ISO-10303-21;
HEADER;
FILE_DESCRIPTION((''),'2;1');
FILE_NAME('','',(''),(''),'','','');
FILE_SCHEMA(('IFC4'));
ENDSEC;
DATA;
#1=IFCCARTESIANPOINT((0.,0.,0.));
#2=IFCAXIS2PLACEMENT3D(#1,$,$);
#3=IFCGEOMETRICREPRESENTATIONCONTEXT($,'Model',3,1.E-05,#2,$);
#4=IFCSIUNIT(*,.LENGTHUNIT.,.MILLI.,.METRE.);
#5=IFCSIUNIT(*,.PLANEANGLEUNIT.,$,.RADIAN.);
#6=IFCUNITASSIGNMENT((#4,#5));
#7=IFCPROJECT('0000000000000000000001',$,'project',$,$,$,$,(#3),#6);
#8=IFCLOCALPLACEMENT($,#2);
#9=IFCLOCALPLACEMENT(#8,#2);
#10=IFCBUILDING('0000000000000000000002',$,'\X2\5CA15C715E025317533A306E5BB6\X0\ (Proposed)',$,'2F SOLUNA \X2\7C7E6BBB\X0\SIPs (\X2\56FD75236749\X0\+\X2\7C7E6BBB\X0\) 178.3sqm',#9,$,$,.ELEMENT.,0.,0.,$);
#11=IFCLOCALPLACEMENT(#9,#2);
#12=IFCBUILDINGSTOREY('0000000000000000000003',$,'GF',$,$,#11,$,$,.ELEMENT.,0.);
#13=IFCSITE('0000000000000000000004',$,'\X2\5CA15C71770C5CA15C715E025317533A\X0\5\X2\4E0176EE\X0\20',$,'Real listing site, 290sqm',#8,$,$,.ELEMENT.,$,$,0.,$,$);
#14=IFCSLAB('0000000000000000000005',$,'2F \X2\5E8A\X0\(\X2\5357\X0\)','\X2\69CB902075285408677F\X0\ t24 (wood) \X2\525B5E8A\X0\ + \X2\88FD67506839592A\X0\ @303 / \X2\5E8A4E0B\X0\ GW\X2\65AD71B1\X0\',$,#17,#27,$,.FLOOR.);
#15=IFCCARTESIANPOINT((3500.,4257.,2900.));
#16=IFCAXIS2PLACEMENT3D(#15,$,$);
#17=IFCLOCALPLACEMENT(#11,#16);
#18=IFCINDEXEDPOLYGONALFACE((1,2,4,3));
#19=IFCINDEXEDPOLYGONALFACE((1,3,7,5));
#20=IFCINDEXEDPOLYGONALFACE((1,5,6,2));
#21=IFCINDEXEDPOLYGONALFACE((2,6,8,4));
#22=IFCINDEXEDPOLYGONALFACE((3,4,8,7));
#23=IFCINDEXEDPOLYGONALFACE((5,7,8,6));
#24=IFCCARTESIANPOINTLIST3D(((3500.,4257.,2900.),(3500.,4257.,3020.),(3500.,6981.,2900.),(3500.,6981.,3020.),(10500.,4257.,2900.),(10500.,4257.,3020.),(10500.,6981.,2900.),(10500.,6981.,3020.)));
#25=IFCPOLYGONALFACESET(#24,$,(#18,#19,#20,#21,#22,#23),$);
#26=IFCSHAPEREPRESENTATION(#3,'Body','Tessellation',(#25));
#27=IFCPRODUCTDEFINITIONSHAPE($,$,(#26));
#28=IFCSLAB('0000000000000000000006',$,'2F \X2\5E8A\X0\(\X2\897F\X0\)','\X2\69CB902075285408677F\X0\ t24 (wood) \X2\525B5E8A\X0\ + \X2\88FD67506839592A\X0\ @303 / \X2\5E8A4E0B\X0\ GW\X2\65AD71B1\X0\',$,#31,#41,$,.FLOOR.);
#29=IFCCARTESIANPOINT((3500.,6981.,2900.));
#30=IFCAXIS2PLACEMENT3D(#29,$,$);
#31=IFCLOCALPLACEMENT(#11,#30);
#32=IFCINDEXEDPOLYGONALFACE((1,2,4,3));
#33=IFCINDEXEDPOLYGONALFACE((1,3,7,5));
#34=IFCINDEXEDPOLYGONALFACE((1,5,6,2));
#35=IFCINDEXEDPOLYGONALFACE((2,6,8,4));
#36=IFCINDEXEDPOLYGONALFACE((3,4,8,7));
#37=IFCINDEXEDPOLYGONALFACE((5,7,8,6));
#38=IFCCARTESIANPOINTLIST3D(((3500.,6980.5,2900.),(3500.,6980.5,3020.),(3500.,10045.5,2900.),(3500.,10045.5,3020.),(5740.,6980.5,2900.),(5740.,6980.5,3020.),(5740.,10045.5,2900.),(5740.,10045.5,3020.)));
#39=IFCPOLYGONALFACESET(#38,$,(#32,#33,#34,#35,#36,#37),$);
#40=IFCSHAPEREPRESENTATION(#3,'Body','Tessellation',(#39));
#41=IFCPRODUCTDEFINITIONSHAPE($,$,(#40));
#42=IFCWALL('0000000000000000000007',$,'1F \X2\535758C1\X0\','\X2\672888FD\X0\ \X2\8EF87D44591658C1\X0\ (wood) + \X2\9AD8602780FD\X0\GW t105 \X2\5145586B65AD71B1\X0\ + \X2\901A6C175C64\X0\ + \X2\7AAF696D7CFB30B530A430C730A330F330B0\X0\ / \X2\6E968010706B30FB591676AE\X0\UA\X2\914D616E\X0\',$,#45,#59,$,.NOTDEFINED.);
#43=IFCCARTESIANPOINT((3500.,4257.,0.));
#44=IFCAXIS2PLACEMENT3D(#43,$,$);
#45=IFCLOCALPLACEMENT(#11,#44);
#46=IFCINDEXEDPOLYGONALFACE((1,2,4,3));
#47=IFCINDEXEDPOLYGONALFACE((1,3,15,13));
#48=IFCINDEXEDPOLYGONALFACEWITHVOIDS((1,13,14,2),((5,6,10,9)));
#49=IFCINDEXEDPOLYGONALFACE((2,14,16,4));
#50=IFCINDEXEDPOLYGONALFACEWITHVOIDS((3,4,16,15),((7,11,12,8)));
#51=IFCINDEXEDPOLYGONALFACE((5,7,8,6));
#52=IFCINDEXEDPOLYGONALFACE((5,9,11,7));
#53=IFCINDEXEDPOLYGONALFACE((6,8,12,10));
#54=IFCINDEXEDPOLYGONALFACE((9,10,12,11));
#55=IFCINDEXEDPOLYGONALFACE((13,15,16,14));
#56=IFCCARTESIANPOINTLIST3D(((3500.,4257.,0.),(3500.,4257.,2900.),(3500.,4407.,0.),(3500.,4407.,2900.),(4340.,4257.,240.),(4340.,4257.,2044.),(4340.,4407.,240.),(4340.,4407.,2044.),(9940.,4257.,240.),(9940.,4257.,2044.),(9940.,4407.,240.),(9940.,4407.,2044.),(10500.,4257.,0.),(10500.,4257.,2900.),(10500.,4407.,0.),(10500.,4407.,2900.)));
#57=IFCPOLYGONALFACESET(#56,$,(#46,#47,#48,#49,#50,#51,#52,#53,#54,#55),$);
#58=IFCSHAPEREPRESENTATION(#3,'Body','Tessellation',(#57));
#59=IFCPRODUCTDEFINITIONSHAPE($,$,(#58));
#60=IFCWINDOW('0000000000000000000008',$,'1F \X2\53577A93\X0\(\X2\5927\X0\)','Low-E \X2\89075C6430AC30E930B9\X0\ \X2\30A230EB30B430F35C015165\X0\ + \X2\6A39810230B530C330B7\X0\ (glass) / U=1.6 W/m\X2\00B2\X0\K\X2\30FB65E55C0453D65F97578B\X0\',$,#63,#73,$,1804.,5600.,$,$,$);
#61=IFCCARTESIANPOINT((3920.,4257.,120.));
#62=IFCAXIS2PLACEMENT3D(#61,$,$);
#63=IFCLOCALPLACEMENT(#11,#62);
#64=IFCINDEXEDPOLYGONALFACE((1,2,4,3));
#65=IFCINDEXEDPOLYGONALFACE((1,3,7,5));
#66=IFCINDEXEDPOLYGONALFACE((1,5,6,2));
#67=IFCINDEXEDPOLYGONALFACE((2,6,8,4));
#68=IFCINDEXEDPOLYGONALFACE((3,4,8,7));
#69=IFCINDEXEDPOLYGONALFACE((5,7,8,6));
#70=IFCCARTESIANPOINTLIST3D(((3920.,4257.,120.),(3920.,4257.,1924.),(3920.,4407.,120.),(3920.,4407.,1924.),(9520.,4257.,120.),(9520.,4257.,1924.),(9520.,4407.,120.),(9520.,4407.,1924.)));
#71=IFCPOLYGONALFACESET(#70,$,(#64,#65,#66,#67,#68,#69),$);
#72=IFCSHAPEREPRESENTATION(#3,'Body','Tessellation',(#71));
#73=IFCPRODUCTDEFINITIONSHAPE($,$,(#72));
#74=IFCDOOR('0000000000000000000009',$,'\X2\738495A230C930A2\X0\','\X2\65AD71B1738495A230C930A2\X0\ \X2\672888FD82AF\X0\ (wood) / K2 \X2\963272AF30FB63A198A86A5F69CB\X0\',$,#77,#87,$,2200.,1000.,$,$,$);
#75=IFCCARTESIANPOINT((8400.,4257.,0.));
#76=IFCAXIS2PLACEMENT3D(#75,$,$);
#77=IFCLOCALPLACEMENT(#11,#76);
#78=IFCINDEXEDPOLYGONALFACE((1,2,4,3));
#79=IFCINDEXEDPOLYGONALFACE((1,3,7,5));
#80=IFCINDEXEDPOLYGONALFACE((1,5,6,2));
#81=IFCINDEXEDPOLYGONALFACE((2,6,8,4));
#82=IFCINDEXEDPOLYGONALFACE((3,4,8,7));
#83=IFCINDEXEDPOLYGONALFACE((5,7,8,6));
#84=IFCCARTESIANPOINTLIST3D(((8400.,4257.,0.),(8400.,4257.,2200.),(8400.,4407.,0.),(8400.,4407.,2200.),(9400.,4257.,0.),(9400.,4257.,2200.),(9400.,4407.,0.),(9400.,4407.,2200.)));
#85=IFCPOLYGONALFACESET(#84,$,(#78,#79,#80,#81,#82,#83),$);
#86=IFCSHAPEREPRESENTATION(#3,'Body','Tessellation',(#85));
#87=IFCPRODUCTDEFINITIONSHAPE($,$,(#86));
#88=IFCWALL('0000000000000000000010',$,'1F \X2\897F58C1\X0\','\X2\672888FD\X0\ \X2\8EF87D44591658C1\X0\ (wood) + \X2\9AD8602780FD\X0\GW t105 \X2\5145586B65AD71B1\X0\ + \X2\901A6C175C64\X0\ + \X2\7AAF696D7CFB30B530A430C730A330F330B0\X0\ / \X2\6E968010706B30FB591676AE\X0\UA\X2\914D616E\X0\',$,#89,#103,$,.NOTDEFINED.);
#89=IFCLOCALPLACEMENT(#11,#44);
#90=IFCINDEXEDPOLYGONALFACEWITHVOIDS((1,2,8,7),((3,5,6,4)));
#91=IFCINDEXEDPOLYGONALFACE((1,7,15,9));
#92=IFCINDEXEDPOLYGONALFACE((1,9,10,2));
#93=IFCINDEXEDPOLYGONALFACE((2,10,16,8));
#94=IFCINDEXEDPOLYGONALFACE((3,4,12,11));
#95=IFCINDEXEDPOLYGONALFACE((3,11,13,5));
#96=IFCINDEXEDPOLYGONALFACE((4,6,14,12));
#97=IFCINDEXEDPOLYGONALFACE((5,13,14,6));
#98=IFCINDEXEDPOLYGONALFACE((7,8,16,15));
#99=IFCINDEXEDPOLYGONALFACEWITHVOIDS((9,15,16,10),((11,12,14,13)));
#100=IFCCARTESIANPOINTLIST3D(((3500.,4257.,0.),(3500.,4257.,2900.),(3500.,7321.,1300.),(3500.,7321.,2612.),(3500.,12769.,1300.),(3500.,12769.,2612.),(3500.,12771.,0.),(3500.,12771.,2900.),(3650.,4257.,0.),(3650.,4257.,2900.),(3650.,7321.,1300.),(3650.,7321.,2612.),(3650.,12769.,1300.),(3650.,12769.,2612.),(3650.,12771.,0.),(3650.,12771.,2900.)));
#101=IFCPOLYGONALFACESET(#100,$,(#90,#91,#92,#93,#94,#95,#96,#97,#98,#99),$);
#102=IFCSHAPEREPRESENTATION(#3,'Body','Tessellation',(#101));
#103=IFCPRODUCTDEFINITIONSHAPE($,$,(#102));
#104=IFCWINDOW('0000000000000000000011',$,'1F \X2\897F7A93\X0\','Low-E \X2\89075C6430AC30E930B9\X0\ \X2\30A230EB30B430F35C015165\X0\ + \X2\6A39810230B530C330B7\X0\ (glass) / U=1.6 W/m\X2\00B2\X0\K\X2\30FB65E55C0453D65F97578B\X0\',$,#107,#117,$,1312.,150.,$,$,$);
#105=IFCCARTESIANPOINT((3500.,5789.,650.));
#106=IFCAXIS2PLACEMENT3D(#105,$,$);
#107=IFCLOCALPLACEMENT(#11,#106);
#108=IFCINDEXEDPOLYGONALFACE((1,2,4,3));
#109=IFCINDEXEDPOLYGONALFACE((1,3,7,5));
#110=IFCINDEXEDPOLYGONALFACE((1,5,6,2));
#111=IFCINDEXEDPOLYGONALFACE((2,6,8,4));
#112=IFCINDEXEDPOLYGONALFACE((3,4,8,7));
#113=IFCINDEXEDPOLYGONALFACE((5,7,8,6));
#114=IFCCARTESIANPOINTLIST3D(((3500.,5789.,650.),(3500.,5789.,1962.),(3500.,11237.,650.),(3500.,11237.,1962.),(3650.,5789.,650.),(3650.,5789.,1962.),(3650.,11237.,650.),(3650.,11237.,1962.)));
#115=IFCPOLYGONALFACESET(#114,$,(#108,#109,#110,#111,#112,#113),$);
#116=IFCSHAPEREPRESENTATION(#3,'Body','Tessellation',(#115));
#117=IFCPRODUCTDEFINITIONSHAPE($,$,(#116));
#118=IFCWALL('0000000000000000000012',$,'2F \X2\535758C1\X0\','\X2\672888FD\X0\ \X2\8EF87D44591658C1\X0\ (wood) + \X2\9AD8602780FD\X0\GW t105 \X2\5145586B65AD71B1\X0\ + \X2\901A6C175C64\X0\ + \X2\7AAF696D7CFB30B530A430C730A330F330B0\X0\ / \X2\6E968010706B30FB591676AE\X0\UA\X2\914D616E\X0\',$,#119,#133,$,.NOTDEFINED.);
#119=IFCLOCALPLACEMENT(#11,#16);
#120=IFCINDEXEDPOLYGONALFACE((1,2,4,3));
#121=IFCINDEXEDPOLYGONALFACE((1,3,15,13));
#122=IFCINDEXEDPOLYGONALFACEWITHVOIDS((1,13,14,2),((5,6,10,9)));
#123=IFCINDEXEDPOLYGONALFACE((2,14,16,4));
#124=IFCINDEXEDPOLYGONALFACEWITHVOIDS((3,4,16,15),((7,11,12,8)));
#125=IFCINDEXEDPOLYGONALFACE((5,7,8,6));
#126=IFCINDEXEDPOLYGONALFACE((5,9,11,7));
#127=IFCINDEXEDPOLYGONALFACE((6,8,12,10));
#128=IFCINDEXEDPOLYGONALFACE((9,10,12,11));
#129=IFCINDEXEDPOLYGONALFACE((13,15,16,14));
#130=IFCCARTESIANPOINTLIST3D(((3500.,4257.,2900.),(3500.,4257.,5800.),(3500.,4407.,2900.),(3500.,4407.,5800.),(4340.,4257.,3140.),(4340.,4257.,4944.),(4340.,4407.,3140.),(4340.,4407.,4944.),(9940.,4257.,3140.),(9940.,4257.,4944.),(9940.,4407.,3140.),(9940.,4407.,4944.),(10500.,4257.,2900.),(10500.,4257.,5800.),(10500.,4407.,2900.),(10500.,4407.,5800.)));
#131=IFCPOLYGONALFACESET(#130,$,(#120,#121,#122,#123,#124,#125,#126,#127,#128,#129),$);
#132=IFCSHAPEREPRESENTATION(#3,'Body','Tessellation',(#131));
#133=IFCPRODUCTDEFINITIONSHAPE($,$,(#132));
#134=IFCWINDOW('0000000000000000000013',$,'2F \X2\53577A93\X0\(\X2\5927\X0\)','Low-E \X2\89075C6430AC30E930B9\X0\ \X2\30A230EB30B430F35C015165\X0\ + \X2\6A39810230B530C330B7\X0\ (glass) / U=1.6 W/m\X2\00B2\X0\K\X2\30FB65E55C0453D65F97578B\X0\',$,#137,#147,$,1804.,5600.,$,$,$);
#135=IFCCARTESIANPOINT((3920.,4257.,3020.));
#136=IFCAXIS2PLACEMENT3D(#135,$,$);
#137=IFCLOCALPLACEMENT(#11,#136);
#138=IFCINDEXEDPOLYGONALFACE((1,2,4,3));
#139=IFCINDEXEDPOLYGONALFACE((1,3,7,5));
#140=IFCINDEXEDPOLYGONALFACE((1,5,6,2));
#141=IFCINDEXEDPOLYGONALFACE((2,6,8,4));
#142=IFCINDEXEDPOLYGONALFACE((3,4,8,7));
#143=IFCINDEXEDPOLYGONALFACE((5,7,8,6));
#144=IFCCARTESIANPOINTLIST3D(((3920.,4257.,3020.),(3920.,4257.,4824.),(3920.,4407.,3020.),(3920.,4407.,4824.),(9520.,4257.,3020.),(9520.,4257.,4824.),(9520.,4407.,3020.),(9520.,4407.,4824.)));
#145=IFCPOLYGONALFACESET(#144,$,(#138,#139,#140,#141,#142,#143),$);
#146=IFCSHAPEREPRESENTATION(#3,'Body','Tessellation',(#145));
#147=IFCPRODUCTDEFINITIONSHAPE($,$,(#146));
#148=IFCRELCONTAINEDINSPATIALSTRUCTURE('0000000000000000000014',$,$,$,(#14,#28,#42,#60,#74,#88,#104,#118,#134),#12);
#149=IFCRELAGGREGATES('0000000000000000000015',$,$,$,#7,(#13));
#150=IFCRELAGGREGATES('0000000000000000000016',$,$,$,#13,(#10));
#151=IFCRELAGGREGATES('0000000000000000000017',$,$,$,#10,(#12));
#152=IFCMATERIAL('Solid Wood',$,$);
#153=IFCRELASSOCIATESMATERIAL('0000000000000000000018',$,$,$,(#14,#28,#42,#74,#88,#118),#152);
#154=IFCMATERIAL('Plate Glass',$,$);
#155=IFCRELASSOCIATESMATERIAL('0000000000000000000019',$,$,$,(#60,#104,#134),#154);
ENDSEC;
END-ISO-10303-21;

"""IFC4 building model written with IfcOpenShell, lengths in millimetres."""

from ifc_helpers import new_model, si_unit, frame, frame_2d, origin, place, context, project, spatial, rectangle, extrude, material, element, fill, save


model = new_model("IFC4")

# Units and contexts
model_context = context("Model", 3, precision=1e-05, world=origin())
ifc_project = project(units=[si_unit("LENGTHUNIT", "METRE", prefix="MILLI"), si_unit("PLANEANGLEUNIT", "RADIAN")], contexts=[model_context])

# Site, building, storey
site_placement = place(None, origin())
site = spatial("IfcSite", under=ifc_project, at=site_placement, Name="岡山県岡山市北区5丁目20", ObjectType="Real listing site, 290sqm", CompositionType="ELEMENT", RefElevation=0.0)
building_placement = place(site_placement, origin())
building = spatial("IfcBuilding", under=site, at=building_placement, Name="岡山市北区の家 (Proposed)", ObjectType="2F SOLUNA 籾殻SIPs (国産杉+籾殻) 178.3sqm", CompositionType="ELEMENT", ElevationOfRefHeight=0.0, ElevationOfTerrain=0.0)
storey_placement = place(building_placement, origin())
storey = spatial("IfcBuildingStorey", under=building, at=storey_placement, Name="GF", CompositionType="ELEMENT", Elevation=0.0)

# Slabs
ifc_material_1 = material(Name="Solid Wood")
slab_1_placement = place(storey_placement, frame((3500.0, 4257.0, 2900.0)))
element("IfcSlab", 1, at=slab_1_placement, inside=storey, material=ifc_material_1, Name="2F 床(南)", Description="構造用合板 t24 (wood) 剛床 + 製材根太 @303 / 床下 GW断熱", PredefinedType="FLOOR", context=model_context, shape_type="SweptSolid", body=[
    extrude(rectangle(XDim=7000.0, YDim=2724.0, at=frame_2d((3500.0, 1362.0))), frame((3500.0, 4257.0, 2900.0)), (0.0, 0.0, 1.0), 120.0),
])
slab_2_placement = place(storey_placement, frame((3500.0, 6981.0, 2900.0)))
element("IfcSlab", 2, at=slab_2_placement, inside=storey, material=ifc_material_1, Name="2F 床(西)", Description="構造用合板 t24 (wood) 剛床 + 製材根太 @303 / 床下 GW断熱", PredefinedType="FLOOR", context=model_context, shape_type="SweptSolid", body=[
    extrude(rectangle(XDim=2240.0, YDim=3065.0, at=frame_2d((1120.0, 1532.0))), frame((3500.0, 6981.0, 2900.0)), (0.0, 0.0, 1.0), 120.0),
])

# Wall, openings, window, door
wall_1_placement = place(storey_placement, frame((3500.0, 4257.0, 0.0)))
wall_1 = element("IfcWall", 3, at=wall_1_placement, inside=storey, material=ifc_material_1, Name="1F 南壁", Description="木製 軸組外壁 (wood) + 高性能GW t105 充填断熱 + 通気層 + 窯業系サイディング / 準耐火・外皮UA配慮", PredefinedType="NOTDEFINED", context=model_context, shape_type="SweptSolid", body=[
    extrude(rectangle(XDim=7000.0, YDim=150.0, at=frame_2d((3500.0, 75.0))), frame((3500.0, 4257.0, 0.0)), (0.0, 0.0, 1.0), 2900.0),
])
opening_1_placement = place(storey_placement, frame((3920.0, 4257.0, 120.0)))
opening_1 = element("IfcOpeningElement", 4, at=opening_1_placement, cuts=wall_1, PredefinedType="NOTDEFINED", context=model_context, shape_type="SweptSolid", body=[
    extrude(rectangle(XDim=5600.0, YDim=150.0, at=frame_2d((2800.0, 75.0))), frame((3920.0, 4257.0, 120.0)), (0.0, 0.0, 1.0), 1804.0),
])
opening_2_placement = place(storey_placement, frame((8400.0, 4257.0, 0.0)))
opening_2 = element("IfcOpeningElement", 5, at=opening_2_placement, cuts=wall_1, PredefinedType="NOTDEFINED", context=model_context, shape_type="SweptSolid", body=[
    extrude(rectangle(XDim=1000.0, YDim=150.0, at=frame_2d((500.0, 75.0))), frame((8400.0, 4257.0, 0.0)), (0.0, 0.0, 1.0), 2200.0),
])
ifc_material_2 = material(Name="Plate Glass")
window_1_placement = place(storey_placement, frame((3920.0, 4257.0, 120.0)))
window_1 = element("IfcWindow", 6, at=window_1_placement, inside=storey, material=ifc_material_2, Name="1F 南窓(大)", Description="Low-E 複層ガラス アルゴン封入 + 樹脂サッシ (glass) / U=1.6 W/m²K・日射取得型", OverallHeight=1804.0, OverallWidth=5600.0, context=model_context, shape_type="SweptSolid", body=[
    extrude(rectangle(XDim=5600.0, YDim=150.0, at=frame_2d((2800.0, 75.0))), frame((3920.0, 4257.0, 120.0)), (0.0, 0.0, 1.0), 1804.0),
])
fill(opening_1, window_1)
door_placement = place(storey_placement, frame((8400.0, 4257.0, 0.0)))
door = element("IfcDoor", 7, at=door_placement, inside=storey, material=ifc_material_1, Name="玄関ドア", Description="断熱玄関ドア 木製芯 (wood) / K2 防犯・採風機構", OverallHeight=2200.0, OverallWidth=1000.0, context=model_context, shape_type="SweptSolid", body=[
    extrude(rectangle(XDim=1000.0, YDim=150.0, at=frame_2d((500.0, 75.0))), frame((8400.0, 4257.0, 0.0)), (0.0, 0.0, 1.0), 2200.0),
])
fill(opening_2, door)

# Walls, openings, windows
wall_2_placement = place(storey_placement, frame((3500.0, 4257.0, 0.0)))
wall_2 = element("IfcWall", 8, at=wall_2_placement, inside=storey, material=ifc_material_1, Name="1F 西壁", Description="木製 軸組外壁 (wood) + 高性能GW t105 充填断熱 + 通気層 + 窯業系サイディング / 準耐火・外皮UA配慮", PredefinedType="NOTDEFINED", context=model_context, shape_type="SweptSolid", body=[
    extrude(rectangle(XDim=150.0, YDim=8514.0, at=frame_2d((75.0, 4257.0))), frame((3500.0, 4257.0, 0.0)), (0.0, 0.0, 1.0), 2900.0),
])
opening_3_placement = place(storey_placement, frame((3500.0, 5789.0, 650.0)))
opening_3 = element("IfcOpeningElement", 9, at=opening_3_placement, cuts=wall_2, PredefinedType="NOTDEFINED", context=model_context, shape_type="SweptSolid", body=[
    extrude(rectangle(XDim=150.0, YDim=5448.0, at=frame_2d((75.0, 2724.0))), frame((3500.0, 5789.0, 650.0)), (0.0, 0.0, 1.0), 1312.0),
])
window_2_placement = place(storey_placement, frame((3500.0, 5789.0, 650.0)))
window_2 = element("IfcWindow", 10, at=window_2_placement, inside=storey, material=ifc_material_2, Name="1F 西窓", Description="Low-E 複層ガラス アルゴン封入 + 樹脂サッシ (glass) / U=1.6 W/m²K・日射取得型", OverallHeight=1312.0, OverallWidth=150.0, context=model_context, shape_type="SweptSolid", body=[
    extrude(rectangle(XDim=150.0, YDim=5448.0, at=frame_2d((75.0, 2724.0))), frame((3500.0, 5789.0, 650.0)), (0.0, 0.0, 1.0), 1312.0),
])
fill(opening_3, window_2)
wall_3_placement = place(storey_placement, frame((3500.0, 4257.0, 2900.0)))
wall_3 = element("IfcWall", 11, at=wall_3_placement, inside=storey, material=ifc_material_1, Name="2F 南壁", Description="木製 軸組外壁 (wood) + 高性能GW t105 充填断熱 + 通気層 + 窯業系サイディング / 準耐火・外皮UA配慮", PredefinedType="NOTDEFINED", context=model_context, shape_type="SweptSolid", body=[
    extrude(rectangle(XDim=7000.0, YDim=150.0, at=frame_2d((3500.0, 75.0))), frame((3500.0, 4257.0, 2900.0)), (0.0, 0.0, 1.0), 2900.0),
])
opening_4_placement = place(storey_placement, frame((3920.0, 4257.0, 3020.0)))
opening_4 = element("IfcOpeningElement", 12, at=opening_4_placement, cuts=wall_3, PredefinedType="NOTDEFINED", context=model_context, shape_type="SweptSolid", body=[
    extrude(rectangle(XDim=5600.0, YDim=150.0, at=frame_2d((2800.0, 75.0))), frame((3920.0, 4257.0, 3020.0)), (0.0, 0.0, 1.0), 1804.0),
])
window_3_placement = place(storey_placement, frame((3920.0, 4257.0, 3020.0)))
window_3 = element("IfcWindow", 13, at=window_3_placement, inside=storey, material=ifc_material_2, Name="2F 南窓(大)", Description="Low-E 複層ガラス アルゴン封入 + 樹脂サッシ (glass) / U=1.6 W/m²K・日射取得型", OverallHeight=1804.0, OverallWidth=5600.0, context=model_context, shape_type="SweptSolid", body=[
    extrude(rectangle(XDim=5600.0, YDim=150.0, at=frame_2d((2800.0, 75.0))), frame((3920.0, 4257.0, 3020.0)), (0.0, 0.0, 1.0), 1804.0),
])
fill(opening_4, window_3)

save(model, "model.ifc")
